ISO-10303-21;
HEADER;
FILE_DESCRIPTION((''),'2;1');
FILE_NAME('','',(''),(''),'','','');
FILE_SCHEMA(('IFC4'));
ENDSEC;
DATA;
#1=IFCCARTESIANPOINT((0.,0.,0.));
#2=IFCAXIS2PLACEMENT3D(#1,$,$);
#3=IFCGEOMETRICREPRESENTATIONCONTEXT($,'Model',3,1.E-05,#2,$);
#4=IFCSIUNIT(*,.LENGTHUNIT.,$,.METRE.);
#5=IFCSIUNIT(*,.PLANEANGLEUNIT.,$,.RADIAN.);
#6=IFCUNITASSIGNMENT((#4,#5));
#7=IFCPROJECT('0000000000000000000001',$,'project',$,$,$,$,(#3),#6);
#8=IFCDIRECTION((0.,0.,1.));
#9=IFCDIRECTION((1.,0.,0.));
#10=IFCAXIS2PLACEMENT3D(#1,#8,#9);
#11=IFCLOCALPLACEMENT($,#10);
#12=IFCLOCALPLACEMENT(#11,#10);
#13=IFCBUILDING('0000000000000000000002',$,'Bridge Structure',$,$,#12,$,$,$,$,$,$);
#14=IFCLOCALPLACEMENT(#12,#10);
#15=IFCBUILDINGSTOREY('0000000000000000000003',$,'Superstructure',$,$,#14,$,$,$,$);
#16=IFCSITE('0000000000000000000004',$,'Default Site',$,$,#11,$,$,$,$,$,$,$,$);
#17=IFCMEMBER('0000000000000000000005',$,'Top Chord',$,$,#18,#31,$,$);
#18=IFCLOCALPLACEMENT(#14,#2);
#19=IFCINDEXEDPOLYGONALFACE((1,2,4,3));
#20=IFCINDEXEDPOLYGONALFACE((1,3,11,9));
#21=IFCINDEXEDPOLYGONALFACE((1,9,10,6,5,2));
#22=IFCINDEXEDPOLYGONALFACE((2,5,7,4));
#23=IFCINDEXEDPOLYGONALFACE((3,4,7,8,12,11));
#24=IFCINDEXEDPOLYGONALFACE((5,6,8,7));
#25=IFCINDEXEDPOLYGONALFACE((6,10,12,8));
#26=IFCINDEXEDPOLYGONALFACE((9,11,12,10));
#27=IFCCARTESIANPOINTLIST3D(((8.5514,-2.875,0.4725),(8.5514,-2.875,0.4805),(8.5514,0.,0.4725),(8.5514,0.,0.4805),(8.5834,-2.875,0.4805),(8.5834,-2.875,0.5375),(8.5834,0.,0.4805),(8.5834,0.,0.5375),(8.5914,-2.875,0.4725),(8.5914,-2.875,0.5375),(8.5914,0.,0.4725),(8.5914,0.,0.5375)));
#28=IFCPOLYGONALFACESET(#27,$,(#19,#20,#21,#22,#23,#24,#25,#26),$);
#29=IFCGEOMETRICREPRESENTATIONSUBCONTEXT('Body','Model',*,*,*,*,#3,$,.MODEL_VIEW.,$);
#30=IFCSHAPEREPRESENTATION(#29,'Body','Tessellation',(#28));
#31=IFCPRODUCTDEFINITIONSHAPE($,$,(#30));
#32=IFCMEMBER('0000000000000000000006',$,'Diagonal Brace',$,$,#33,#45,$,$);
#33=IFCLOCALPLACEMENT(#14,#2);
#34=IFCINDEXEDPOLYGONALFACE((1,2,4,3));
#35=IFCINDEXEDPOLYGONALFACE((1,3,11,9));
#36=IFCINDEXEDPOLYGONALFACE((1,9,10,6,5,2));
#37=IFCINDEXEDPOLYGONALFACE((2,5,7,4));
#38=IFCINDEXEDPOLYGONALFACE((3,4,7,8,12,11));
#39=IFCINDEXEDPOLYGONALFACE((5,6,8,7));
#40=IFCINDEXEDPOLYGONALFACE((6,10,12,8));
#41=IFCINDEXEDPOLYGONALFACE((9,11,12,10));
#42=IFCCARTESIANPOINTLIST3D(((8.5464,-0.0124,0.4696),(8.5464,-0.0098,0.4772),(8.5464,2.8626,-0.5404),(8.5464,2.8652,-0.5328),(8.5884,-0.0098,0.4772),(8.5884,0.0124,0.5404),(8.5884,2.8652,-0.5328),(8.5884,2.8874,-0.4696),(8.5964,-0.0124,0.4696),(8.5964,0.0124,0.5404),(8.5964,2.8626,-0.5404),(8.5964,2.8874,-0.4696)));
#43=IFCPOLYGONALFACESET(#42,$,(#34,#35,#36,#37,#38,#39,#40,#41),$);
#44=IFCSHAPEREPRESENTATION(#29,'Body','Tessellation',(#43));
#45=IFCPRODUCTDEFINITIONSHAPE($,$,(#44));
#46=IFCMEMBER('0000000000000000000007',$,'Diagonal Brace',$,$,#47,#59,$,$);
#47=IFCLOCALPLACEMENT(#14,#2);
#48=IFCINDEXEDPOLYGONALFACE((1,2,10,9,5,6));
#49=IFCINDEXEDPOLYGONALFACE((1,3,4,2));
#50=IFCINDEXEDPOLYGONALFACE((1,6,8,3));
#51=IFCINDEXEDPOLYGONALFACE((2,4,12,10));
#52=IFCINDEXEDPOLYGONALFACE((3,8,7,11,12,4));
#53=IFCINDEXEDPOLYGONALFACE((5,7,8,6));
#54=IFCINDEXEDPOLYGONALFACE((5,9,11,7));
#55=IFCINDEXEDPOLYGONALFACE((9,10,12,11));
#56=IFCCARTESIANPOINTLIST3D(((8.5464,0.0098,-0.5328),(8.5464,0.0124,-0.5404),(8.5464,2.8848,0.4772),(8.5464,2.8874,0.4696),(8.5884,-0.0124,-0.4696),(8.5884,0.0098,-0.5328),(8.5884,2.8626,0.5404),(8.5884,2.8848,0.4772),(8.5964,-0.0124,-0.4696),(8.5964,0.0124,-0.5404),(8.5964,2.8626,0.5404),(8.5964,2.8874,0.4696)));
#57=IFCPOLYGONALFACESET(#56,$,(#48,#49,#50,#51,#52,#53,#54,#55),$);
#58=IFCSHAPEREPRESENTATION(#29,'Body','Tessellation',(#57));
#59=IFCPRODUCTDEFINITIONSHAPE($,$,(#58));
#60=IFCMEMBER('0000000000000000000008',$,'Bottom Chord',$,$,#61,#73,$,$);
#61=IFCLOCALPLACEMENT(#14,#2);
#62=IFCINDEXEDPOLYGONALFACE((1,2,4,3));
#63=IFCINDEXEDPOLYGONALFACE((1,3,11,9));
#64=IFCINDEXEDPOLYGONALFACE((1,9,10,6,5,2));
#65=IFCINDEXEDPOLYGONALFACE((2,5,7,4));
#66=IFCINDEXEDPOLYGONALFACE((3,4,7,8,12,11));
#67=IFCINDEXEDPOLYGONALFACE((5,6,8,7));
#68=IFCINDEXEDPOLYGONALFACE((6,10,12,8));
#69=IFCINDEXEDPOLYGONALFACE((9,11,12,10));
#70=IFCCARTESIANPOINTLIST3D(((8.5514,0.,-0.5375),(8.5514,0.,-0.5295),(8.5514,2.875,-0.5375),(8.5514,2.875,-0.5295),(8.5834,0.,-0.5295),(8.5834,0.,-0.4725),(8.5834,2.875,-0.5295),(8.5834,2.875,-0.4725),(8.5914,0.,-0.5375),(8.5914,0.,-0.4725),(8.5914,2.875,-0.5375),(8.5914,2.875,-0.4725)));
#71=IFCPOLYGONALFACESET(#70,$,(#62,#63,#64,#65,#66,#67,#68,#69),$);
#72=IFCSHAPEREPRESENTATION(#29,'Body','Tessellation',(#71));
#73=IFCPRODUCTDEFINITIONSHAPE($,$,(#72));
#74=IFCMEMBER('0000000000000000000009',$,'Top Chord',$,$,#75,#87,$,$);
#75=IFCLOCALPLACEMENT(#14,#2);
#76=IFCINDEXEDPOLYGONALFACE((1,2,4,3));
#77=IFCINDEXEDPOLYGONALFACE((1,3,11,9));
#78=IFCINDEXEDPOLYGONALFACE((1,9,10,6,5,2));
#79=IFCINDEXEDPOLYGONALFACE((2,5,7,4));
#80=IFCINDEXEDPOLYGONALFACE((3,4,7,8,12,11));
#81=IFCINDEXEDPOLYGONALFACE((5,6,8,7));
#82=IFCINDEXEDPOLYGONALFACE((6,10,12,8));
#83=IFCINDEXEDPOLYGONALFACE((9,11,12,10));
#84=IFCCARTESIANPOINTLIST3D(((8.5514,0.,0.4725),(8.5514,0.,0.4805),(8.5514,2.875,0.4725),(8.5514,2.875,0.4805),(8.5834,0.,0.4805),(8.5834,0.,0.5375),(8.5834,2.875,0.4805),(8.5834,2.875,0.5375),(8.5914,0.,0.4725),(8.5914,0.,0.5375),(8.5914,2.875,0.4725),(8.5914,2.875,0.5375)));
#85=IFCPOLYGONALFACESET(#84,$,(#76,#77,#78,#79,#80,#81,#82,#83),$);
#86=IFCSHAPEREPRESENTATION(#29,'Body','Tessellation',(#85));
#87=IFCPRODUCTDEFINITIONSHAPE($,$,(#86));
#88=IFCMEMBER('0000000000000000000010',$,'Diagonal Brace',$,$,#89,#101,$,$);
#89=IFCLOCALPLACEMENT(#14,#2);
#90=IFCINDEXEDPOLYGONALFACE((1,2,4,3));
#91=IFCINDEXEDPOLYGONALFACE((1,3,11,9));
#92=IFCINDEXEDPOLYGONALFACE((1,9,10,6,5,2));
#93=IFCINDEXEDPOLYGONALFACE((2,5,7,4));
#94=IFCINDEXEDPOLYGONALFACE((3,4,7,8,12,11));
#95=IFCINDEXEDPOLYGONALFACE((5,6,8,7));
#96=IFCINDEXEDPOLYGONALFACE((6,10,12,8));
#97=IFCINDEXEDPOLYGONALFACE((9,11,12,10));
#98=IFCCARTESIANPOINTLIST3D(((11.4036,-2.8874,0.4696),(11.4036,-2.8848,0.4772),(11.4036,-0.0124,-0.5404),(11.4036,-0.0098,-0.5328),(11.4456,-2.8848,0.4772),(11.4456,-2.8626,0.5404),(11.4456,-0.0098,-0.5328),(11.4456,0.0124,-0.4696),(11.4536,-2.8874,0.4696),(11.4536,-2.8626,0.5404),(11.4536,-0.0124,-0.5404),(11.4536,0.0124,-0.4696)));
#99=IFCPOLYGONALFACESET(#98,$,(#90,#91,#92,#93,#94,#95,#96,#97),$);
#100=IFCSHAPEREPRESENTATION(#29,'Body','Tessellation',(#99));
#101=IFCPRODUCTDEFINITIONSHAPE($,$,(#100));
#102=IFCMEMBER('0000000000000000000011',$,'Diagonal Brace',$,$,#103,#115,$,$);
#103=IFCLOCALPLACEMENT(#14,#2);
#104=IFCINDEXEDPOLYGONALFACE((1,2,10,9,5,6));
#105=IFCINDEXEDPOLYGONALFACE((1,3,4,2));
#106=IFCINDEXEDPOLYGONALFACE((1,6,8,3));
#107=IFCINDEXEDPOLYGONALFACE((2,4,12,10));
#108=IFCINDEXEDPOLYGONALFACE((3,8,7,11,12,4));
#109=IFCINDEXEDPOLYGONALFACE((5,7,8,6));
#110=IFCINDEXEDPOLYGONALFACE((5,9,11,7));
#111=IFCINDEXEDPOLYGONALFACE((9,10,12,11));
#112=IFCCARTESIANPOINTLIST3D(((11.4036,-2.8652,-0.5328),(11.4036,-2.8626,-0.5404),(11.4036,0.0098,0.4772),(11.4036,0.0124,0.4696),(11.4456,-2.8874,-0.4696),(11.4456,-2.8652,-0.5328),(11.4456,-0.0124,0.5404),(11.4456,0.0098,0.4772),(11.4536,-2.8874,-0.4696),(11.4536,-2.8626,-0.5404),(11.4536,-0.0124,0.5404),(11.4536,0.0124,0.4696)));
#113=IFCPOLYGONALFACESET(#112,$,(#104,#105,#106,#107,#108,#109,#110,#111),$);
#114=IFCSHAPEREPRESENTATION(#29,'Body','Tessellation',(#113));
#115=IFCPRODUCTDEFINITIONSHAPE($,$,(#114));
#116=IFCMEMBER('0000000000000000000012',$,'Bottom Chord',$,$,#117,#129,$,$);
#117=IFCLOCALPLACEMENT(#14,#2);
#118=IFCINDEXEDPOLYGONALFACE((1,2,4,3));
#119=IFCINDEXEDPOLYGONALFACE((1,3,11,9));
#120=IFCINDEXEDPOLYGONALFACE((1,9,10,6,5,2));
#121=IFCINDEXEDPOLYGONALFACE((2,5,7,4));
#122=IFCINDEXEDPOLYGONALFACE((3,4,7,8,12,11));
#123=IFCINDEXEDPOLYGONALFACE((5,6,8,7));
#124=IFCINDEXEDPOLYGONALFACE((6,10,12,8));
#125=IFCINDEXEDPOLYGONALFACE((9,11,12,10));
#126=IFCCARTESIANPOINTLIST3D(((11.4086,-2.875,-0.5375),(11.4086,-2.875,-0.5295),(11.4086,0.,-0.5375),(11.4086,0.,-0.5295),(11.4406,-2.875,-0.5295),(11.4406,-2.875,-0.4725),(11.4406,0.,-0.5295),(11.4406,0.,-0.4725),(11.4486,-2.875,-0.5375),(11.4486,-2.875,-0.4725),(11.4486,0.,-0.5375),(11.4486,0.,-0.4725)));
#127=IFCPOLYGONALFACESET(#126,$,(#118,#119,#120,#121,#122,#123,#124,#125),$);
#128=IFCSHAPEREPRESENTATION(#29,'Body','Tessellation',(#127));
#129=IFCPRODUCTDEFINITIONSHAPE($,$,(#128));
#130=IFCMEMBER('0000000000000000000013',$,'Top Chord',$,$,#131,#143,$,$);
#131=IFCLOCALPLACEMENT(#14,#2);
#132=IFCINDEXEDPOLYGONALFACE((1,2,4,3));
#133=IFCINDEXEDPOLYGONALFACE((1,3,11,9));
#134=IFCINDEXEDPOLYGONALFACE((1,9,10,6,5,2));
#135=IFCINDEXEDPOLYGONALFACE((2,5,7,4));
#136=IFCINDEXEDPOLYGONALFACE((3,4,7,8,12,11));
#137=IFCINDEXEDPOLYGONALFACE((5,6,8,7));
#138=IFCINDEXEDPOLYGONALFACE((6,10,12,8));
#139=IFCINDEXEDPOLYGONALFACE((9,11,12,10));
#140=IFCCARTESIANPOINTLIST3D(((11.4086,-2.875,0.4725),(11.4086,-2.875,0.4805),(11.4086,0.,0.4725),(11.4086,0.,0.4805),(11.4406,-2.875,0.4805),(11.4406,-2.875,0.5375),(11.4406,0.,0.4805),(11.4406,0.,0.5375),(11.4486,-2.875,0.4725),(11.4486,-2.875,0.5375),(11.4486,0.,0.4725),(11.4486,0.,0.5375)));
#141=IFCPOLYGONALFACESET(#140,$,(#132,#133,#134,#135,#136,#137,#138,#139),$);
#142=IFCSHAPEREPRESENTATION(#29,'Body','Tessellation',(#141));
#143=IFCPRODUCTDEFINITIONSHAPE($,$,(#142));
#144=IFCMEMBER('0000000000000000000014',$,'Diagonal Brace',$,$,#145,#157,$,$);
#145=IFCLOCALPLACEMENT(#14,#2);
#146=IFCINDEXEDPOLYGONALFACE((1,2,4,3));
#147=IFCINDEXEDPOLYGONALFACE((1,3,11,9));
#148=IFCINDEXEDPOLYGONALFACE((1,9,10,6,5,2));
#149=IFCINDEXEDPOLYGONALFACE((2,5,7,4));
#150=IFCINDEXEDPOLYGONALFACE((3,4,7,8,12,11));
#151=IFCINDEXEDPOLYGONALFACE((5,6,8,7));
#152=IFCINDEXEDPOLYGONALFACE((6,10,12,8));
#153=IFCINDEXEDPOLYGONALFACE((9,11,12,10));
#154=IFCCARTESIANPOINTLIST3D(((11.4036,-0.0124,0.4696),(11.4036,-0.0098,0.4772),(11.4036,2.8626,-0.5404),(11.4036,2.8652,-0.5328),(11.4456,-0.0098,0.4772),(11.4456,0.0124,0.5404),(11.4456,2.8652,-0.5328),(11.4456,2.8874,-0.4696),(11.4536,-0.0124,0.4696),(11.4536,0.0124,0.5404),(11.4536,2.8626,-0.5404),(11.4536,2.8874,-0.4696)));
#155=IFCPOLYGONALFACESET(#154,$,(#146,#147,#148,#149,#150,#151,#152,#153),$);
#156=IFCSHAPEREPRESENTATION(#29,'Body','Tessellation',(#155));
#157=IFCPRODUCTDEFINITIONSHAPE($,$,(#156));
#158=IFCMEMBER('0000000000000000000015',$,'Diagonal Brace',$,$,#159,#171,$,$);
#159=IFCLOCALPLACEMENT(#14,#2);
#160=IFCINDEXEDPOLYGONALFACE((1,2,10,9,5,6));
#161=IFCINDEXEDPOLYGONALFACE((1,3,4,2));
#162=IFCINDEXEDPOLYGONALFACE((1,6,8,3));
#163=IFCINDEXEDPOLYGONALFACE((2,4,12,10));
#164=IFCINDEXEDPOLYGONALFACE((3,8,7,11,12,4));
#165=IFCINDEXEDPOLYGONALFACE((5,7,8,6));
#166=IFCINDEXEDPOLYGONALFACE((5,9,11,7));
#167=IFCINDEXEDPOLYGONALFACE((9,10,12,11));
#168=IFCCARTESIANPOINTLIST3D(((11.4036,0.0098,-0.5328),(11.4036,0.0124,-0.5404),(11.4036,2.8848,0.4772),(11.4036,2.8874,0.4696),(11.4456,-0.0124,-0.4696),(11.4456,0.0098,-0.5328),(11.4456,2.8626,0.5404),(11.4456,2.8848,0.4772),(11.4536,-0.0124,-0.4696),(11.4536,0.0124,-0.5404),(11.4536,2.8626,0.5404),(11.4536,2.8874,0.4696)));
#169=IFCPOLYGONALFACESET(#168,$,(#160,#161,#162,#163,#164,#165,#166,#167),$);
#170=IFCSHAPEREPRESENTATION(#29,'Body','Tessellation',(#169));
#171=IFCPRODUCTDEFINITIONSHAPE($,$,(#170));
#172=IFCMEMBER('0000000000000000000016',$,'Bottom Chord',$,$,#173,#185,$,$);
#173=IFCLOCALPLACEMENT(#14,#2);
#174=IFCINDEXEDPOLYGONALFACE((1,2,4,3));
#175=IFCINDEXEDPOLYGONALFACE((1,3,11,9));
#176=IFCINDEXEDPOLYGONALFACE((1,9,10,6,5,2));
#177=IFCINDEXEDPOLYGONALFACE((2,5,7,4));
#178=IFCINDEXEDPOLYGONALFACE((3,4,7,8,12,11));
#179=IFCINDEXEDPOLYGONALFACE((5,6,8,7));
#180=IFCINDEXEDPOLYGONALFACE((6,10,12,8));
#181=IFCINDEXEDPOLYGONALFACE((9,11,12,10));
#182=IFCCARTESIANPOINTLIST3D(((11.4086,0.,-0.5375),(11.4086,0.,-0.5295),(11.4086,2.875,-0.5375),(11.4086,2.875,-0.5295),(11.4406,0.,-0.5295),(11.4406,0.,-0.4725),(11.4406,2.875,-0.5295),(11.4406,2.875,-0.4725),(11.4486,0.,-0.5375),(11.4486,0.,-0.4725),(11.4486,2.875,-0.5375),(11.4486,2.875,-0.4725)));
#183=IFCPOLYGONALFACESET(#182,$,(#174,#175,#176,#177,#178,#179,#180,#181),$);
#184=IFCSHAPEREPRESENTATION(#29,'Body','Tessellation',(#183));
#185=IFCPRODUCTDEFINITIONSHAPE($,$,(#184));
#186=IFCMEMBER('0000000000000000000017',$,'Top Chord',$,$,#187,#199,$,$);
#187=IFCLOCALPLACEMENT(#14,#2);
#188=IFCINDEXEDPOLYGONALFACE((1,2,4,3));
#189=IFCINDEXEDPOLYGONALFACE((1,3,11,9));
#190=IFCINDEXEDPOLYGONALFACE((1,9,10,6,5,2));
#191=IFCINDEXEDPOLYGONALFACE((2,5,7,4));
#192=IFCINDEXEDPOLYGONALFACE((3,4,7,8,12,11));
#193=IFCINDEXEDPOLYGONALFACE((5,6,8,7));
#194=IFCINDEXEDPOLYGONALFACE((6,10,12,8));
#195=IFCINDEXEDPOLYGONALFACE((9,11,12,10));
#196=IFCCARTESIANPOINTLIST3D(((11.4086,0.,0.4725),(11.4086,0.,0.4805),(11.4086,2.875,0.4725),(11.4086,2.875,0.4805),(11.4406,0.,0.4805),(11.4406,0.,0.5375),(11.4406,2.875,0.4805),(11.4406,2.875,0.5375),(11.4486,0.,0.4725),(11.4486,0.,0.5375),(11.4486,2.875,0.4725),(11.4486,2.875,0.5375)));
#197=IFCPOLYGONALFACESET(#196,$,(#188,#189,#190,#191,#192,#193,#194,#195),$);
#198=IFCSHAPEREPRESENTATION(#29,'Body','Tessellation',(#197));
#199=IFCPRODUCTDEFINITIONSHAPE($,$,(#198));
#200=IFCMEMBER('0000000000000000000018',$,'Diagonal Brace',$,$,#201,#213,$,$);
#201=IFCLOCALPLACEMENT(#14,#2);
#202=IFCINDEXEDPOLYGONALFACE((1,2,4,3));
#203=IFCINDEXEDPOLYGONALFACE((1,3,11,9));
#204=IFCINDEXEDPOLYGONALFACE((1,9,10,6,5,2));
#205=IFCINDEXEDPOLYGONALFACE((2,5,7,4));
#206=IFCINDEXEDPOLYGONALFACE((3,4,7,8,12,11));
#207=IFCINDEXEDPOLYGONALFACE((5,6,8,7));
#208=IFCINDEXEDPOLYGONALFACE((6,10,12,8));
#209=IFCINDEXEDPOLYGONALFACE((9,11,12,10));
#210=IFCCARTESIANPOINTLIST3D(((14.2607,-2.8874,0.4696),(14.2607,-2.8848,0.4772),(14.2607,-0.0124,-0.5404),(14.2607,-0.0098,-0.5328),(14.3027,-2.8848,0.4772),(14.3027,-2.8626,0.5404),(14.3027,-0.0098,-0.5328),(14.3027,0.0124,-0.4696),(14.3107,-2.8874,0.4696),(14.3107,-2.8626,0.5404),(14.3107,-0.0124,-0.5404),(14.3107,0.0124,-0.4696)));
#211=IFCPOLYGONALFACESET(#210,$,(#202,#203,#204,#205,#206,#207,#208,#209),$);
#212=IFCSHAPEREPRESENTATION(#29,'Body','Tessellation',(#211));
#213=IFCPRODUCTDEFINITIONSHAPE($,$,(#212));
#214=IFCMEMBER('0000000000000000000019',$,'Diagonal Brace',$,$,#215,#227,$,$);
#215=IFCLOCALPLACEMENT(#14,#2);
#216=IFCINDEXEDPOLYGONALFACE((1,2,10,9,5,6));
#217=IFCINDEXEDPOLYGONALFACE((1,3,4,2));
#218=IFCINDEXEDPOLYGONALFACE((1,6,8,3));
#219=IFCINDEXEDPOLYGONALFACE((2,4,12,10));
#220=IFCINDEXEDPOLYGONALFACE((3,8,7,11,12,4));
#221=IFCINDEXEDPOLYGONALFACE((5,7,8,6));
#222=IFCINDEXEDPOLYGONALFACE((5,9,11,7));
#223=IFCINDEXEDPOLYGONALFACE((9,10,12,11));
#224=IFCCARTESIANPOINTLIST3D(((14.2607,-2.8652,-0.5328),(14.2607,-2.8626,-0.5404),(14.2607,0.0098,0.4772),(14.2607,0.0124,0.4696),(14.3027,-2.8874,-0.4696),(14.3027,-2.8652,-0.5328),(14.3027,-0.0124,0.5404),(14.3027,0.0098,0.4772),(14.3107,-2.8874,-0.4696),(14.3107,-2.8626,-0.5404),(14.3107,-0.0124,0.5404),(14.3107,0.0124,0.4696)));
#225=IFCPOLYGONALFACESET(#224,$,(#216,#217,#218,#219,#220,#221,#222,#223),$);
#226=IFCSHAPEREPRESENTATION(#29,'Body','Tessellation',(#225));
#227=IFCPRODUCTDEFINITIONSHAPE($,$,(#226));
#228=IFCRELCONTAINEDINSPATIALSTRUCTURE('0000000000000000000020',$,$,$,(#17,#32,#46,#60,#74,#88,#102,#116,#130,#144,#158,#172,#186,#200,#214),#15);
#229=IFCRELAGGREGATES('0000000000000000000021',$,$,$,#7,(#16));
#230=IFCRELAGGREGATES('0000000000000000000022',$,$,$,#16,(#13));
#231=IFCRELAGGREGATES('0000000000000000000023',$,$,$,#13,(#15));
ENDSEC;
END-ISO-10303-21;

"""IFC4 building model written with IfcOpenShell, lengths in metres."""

from ifc_helpers import new_model, si_unit, frame, origin, origin_with_axes, origin_2d_with_axis, place, context, subcontext, project, spatial, l_section, extrude, element, save


model = new_model("IFC4")

# Units and contexts
model_context = context("Model", 3, precision=1e-05, world=origin())
body_context = subcontext(model_context, "Body", "Model", "MODEL_VIEW")
ifc_project = project(units=[si_unit("LENGTHUNIT", "METRE"), si_unit("PLANEANGLEUNIT", "RADIAN")], contexts=[model_context])

# Site, building, storey
site_placement = place(None, origin_with_axes())
site = spatial("IfcSite", under=ifc_project, at=site_placement, Name="Default Site")
building_placement = place(site_placement, origin_with_axes())
building = spatial("IfcBuilding", under=site, at=building_placement, Name="Bridge Structure")
storey_placement = place(building_placement, origin_with_axes())
storey = spatial("IfcBuildingStorey", under=building, at=storey_placement, Name="Superstructure")

# Members
member_1_placement = place(storey_placement, frame((8.5714, -2.875, 0.505), z_axis=(0.0, 1.0, 0.0), x_axis=(-1.0, 0.0, 0.0)))
element("IfcMember", 1, at=member_1_placement, inside=storey, Name="Top Chord", context=body_context, shape_type="SweptSolid", body=[
    extrude(l_section(Depth=0.065, Width=0.04, Thickness=0.008, at=origin_2d_with_axis()), origin_with_axes(), (0.0, 0.0, 1.0), 2.875),
])
for number, where, z_axis, x_axis, name in (
    (2, (8.5714, 0.0, 0.505), (0.0, 0.943474, -0.331447), (-1.0, 0.0, 0.0), "Diagonal Brace"),
    (3, (8.5714, 0.0, -0.505), (0.0, 0.943474, 0.331447), (-1.0, 0.0, 0.0), "Diagonal Brace"),
):
    element("IfcMember", number, at=place(storey_placement, frame(where, z_axis=z_axis, x_axis=x_axis)), inside=storey, Name=name, context=body_context, shape_type="SweptSolid", body=[
        extrude(l_section(Depth=0.075, Width=0.05, Thickness=0.008, at=origin_2d_with_axis()), origin_with_axes(), (0.0, 0.0, 1.0), 3.0472),
    ])
for number, where, z_axis, x_axis, name in (
    (4, (8.5714, 0.0, -0.505), (0.0, 1.0, 0.0), (-1.0, 0.0, 0.0), "Bottom Chord"),
    (5, (8.5714, 0.0, 0.505), (0.0, 1.0, 0.0), (-1.0, 0.0, 0.0), "Top Chord"),
):
    element("IfcMember", number, at=place(storey_placement, frame(where, z_axis=z_axis, x_axis=x_axis)), inside=storey, Name=name, context=body_context, shape_type="SweptSolid", body=[
        extrude(l_section(Depth=0.065, Width=0.04, Thickness=0.008, at=origin_2d_with_axis()), origin_with_axes(), (0.0, 0.0, 1.0), 2.875),
    ])
for number, where, z_axis, x_axis, name in (
    (6, (11.4286, -2.875, 0.505), (0.0, 0.943474, -0.331447), (-1.0, 0.0, 0.0), "Diagonal Brace"),
    (7, (11.4286, -2.875, -0.505), (0.0, 0.943474, 0.331447), (-1.0, 0.0, 0.0), "Diagonal Brace"),
):
    element("IfcMember", number, at=place(storey_placement, frame(where, z_axis=z_axis, x_axis=x_axis)), inside=storey, Name=name, context=body_context, shape_type="SweptSolid", body=[
        extrude(l_section(Depth=0.075, Width=0.05, Thickness=0.008, at=origin_2d_with_axis()), origin_with_axes(), (0.0, 0.0, 1.0), 3.0472),
    ])
for number, where, z_axis, x_axis, name in (
    (8, (11.4286, -2.875, -0.505), (0.0, 1.0, 0.0), (-1.0, 0.0, 0.0), "Bottom Chord"),
    (9, (11.4286, -2.875, 0.505), (0.0, 1.0, 0.0), (-1.0, 0.0, 0.0), "Top Chord"),
):
    element("IfcMember", number, at=place(storey_placement, frame(where, z_axis=z_axis, x_axis=x_axis)), inside=storey, Name=name, context=body_context, shape_type="SweptSolid", body=[
        extrude(l_section(Depth=0.065, Width=0.04, Thickness=0.008, at=origin_2d_with_axis()), origin_with_axes(), (0.0, 0.0, 1.0), 2.875),
    ])
for number, where, z_axis, x_axis, name in (
    (10, (11.4286, 0.0, 0.505), (0.0, 0.943474, -0.331447), (-1.0, 0.0, 0.0), "Diagonal Brace"),
    (11, (11.4286, 0.0, -0.505), (0.0, 0.943474, 0.331447), (-1.0, 0.0, 0.0), "Diagonal Brace"),
):
    element("IfcMember", number, at=place(storey_placement, frame(where, z_axis=z_axis, x_axis=x_axis)), inside=storey, Name=name, context=body_context, shape_type="SweptSolid", body=[
        extrude(l_section(Depth=0.075, Width=0.05, Thickness=0.008, at=origin_2d_with_axis()), origin_with_axes(), (0.0, 0.0, 1.0), 3.0472),
    ])
for number, where, z_axis, x_axis, name in (
    (12, (11.4286, 0.0, -0.505), (0.0, 1.0, 0.0), (-1.0, 0.0, 0.0), "Bottom Chord"),
    (13, (11.4286, 0.0, 0.505), (0.0, 1.0, 0.0), (-1.0, 0.0, 0.0), "Top Chord"),
):
    element("IfcMember", number, at=place(storey_placement, frame(where, z_axis=z_axis, x_axis=x_axis)), inside=storey, Name=name, context=body_context, shape_type="SweptSolid", body=[
        extrude(l_section(Depth=0.065, Width=0.04, Thickness=0.008, at=origin_2d_with_axis()), origin_with_axes(), (0.0, 0.0, 1.0), 2.875),
    ])
for number, where, z_axis, x_axis, name in (
    (14, (14.2857, -2.875, 0.505), (0.0, 0.943474, -0.331447), (-1.0, 0.0, 0.0), "Diagonal Brace"),
    (15, (14.2857, -2.875, -0.505), (0.0, 0.943474, 0.331447), (-1.0, 0.0, 0.0), "Diagonal Brace"),
):
    element("IfcMember", number, at=place(storey_placement, frame(where, z_axis=z_axis, x_axis=x_axis)), inside=storey, Name=name, context=body_context, shape_type="SweptSolid", body=[
        extrude(l_section(Depth=0.075, Width=0.05, Thickness=0.008, at=origin_2d_with_axis()), origin_with_axes(), (0.0, 0.0, 1.0), 3.0472),
    ])

save(model, "model.ifc")
